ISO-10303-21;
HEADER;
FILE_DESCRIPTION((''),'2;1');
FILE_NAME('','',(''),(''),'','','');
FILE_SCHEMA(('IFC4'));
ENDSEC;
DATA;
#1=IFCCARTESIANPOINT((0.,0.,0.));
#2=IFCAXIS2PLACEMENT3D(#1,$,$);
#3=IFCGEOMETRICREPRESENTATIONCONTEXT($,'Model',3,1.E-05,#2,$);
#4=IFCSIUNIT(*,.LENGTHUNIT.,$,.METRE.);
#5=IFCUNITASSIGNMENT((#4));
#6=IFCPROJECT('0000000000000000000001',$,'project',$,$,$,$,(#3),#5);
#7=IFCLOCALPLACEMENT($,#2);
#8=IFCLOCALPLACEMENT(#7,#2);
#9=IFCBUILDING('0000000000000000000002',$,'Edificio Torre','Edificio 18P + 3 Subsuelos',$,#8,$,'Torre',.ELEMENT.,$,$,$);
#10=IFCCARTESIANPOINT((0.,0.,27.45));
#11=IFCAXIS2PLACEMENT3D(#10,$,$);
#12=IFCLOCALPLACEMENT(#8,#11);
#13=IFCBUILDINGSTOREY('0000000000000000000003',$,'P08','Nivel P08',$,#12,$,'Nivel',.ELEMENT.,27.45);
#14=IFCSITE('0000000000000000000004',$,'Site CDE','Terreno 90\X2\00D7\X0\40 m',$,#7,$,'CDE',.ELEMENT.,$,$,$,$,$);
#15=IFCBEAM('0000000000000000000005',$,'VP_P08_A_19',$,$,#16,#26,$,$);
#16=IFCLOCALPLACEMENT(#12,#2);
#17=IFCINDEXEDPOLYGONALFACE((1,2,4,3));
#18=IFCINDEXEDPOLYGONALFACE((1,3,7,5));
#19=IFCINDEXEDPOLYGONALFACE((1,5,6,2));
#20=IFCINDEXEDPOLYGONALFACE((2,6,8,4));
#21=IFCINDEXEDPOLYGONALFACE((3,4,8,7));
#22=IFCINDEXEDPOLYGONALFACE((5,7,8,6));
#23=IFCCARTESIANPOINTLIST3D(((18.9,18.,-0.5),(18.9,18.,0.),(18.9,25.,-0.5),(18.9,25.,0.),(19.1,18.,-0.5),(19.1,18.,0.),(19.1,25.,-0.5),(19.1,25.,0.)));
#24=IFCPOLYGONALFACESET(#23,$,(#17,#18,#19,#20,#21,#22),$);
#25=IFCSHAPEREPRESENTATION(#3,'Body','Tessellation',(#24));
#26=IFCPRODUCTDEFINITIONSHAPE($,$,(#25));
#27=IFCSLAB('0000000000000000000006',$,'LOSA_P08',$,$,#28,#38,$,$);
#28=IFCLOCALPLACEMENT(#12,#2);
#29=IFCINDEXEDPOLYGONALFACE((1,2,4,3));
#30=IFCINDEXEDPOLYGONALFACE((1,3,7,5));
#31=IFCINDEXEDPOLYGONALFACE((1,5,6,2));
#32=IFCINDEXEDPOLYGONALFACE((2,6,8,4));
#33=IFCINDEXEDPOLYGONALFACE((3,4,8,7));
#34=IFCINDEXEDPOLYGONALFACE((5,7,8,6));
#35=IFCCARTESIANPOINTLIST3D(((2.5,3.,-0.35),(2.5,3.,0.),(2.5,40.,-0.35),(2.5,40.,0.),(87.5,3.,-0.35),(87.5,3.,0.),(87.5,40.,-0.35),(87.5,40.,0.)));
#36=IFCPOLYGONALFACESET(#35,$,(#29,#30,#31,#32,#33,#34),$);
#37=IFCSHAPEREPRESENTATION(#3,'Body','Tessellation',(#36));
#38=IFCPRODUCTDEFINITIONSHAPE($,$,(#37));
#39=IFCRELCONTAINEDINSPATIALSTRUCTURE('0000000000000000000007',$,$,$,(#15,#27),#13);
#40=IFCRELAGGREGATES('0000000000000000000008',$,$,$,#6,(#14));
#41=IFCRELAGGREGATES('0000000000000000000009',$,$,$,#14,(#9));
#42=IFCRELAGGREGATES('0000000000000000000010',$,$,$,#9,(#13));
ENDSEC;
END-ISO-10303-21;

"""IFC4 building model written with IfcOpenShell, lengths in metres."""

from ifc_helpers import new_model, si_unit, frame, origin, origin_2d, place, context, project, spatial, rectangle, extrude, element, save


model = new_model("IFC4")

# Units and contexts
model_context = context("Model", 3, precision=1e-05, world=origin())
ifc_project = project(units=[si_unit("LENGTHUNIT", "METRE")], contexts=[model_context])

# Site, building, storey
site_placement = place(None, origin())
site = spatial("IfcSite", under=ifc_project, at=site_placement, Name="Site CDE", Description="Terreno 90×40 m", LongName="CDE", CompositionType="ELEMENT")
building_placement = place(site_placement, origin())
building = spatial("IfcBuilding", under=site, at=building_placement, Name="Edificio Torre", Description="Edificio 18P + 3 Subsuelos", LongName="Torre", CompositionType="ELEMENT")
storey_placement = place(building_placement, frame((0.0, 0.0, 27.45)))
storey = spatial("IfcBuildingStorey", under=building, at=storey_placement, Name="P08", Description="Nivel P08", LongName="Nivel", CompositionType="ELEMENT", Elevation=27.45)

# Beam
beam_1_placement = place(storey_placement, frame((19.0, 21.5, -0.5)))
element("IfcBeam", 1, at=beam_1_placement, inside=storey, Name="VP_P08_A_19", context=model_context, shape_type="SweptSolid", body=[
    extrude(rectangle(XDim=0.2, YDim=7.0, at=origin_2d()), origin(), (0.0, 0.0, 1.0), 0.5),
])

# Slab
slab_placement = place(storey_placement, frame((45.0, 21.5, -0.35)))
element("IfcSlab", 2, at=slab_placement, inside=storey, Name="LOSA_P08", context=model_context, shape_type="SweptSolid", body=[
    extrude(rectangle(XDim=85.0, YDim=37.0, at=origin_2d()), origin(), (0.0, 0.0, 1.0), 0.35),
])

save(model, "model.ifc")
